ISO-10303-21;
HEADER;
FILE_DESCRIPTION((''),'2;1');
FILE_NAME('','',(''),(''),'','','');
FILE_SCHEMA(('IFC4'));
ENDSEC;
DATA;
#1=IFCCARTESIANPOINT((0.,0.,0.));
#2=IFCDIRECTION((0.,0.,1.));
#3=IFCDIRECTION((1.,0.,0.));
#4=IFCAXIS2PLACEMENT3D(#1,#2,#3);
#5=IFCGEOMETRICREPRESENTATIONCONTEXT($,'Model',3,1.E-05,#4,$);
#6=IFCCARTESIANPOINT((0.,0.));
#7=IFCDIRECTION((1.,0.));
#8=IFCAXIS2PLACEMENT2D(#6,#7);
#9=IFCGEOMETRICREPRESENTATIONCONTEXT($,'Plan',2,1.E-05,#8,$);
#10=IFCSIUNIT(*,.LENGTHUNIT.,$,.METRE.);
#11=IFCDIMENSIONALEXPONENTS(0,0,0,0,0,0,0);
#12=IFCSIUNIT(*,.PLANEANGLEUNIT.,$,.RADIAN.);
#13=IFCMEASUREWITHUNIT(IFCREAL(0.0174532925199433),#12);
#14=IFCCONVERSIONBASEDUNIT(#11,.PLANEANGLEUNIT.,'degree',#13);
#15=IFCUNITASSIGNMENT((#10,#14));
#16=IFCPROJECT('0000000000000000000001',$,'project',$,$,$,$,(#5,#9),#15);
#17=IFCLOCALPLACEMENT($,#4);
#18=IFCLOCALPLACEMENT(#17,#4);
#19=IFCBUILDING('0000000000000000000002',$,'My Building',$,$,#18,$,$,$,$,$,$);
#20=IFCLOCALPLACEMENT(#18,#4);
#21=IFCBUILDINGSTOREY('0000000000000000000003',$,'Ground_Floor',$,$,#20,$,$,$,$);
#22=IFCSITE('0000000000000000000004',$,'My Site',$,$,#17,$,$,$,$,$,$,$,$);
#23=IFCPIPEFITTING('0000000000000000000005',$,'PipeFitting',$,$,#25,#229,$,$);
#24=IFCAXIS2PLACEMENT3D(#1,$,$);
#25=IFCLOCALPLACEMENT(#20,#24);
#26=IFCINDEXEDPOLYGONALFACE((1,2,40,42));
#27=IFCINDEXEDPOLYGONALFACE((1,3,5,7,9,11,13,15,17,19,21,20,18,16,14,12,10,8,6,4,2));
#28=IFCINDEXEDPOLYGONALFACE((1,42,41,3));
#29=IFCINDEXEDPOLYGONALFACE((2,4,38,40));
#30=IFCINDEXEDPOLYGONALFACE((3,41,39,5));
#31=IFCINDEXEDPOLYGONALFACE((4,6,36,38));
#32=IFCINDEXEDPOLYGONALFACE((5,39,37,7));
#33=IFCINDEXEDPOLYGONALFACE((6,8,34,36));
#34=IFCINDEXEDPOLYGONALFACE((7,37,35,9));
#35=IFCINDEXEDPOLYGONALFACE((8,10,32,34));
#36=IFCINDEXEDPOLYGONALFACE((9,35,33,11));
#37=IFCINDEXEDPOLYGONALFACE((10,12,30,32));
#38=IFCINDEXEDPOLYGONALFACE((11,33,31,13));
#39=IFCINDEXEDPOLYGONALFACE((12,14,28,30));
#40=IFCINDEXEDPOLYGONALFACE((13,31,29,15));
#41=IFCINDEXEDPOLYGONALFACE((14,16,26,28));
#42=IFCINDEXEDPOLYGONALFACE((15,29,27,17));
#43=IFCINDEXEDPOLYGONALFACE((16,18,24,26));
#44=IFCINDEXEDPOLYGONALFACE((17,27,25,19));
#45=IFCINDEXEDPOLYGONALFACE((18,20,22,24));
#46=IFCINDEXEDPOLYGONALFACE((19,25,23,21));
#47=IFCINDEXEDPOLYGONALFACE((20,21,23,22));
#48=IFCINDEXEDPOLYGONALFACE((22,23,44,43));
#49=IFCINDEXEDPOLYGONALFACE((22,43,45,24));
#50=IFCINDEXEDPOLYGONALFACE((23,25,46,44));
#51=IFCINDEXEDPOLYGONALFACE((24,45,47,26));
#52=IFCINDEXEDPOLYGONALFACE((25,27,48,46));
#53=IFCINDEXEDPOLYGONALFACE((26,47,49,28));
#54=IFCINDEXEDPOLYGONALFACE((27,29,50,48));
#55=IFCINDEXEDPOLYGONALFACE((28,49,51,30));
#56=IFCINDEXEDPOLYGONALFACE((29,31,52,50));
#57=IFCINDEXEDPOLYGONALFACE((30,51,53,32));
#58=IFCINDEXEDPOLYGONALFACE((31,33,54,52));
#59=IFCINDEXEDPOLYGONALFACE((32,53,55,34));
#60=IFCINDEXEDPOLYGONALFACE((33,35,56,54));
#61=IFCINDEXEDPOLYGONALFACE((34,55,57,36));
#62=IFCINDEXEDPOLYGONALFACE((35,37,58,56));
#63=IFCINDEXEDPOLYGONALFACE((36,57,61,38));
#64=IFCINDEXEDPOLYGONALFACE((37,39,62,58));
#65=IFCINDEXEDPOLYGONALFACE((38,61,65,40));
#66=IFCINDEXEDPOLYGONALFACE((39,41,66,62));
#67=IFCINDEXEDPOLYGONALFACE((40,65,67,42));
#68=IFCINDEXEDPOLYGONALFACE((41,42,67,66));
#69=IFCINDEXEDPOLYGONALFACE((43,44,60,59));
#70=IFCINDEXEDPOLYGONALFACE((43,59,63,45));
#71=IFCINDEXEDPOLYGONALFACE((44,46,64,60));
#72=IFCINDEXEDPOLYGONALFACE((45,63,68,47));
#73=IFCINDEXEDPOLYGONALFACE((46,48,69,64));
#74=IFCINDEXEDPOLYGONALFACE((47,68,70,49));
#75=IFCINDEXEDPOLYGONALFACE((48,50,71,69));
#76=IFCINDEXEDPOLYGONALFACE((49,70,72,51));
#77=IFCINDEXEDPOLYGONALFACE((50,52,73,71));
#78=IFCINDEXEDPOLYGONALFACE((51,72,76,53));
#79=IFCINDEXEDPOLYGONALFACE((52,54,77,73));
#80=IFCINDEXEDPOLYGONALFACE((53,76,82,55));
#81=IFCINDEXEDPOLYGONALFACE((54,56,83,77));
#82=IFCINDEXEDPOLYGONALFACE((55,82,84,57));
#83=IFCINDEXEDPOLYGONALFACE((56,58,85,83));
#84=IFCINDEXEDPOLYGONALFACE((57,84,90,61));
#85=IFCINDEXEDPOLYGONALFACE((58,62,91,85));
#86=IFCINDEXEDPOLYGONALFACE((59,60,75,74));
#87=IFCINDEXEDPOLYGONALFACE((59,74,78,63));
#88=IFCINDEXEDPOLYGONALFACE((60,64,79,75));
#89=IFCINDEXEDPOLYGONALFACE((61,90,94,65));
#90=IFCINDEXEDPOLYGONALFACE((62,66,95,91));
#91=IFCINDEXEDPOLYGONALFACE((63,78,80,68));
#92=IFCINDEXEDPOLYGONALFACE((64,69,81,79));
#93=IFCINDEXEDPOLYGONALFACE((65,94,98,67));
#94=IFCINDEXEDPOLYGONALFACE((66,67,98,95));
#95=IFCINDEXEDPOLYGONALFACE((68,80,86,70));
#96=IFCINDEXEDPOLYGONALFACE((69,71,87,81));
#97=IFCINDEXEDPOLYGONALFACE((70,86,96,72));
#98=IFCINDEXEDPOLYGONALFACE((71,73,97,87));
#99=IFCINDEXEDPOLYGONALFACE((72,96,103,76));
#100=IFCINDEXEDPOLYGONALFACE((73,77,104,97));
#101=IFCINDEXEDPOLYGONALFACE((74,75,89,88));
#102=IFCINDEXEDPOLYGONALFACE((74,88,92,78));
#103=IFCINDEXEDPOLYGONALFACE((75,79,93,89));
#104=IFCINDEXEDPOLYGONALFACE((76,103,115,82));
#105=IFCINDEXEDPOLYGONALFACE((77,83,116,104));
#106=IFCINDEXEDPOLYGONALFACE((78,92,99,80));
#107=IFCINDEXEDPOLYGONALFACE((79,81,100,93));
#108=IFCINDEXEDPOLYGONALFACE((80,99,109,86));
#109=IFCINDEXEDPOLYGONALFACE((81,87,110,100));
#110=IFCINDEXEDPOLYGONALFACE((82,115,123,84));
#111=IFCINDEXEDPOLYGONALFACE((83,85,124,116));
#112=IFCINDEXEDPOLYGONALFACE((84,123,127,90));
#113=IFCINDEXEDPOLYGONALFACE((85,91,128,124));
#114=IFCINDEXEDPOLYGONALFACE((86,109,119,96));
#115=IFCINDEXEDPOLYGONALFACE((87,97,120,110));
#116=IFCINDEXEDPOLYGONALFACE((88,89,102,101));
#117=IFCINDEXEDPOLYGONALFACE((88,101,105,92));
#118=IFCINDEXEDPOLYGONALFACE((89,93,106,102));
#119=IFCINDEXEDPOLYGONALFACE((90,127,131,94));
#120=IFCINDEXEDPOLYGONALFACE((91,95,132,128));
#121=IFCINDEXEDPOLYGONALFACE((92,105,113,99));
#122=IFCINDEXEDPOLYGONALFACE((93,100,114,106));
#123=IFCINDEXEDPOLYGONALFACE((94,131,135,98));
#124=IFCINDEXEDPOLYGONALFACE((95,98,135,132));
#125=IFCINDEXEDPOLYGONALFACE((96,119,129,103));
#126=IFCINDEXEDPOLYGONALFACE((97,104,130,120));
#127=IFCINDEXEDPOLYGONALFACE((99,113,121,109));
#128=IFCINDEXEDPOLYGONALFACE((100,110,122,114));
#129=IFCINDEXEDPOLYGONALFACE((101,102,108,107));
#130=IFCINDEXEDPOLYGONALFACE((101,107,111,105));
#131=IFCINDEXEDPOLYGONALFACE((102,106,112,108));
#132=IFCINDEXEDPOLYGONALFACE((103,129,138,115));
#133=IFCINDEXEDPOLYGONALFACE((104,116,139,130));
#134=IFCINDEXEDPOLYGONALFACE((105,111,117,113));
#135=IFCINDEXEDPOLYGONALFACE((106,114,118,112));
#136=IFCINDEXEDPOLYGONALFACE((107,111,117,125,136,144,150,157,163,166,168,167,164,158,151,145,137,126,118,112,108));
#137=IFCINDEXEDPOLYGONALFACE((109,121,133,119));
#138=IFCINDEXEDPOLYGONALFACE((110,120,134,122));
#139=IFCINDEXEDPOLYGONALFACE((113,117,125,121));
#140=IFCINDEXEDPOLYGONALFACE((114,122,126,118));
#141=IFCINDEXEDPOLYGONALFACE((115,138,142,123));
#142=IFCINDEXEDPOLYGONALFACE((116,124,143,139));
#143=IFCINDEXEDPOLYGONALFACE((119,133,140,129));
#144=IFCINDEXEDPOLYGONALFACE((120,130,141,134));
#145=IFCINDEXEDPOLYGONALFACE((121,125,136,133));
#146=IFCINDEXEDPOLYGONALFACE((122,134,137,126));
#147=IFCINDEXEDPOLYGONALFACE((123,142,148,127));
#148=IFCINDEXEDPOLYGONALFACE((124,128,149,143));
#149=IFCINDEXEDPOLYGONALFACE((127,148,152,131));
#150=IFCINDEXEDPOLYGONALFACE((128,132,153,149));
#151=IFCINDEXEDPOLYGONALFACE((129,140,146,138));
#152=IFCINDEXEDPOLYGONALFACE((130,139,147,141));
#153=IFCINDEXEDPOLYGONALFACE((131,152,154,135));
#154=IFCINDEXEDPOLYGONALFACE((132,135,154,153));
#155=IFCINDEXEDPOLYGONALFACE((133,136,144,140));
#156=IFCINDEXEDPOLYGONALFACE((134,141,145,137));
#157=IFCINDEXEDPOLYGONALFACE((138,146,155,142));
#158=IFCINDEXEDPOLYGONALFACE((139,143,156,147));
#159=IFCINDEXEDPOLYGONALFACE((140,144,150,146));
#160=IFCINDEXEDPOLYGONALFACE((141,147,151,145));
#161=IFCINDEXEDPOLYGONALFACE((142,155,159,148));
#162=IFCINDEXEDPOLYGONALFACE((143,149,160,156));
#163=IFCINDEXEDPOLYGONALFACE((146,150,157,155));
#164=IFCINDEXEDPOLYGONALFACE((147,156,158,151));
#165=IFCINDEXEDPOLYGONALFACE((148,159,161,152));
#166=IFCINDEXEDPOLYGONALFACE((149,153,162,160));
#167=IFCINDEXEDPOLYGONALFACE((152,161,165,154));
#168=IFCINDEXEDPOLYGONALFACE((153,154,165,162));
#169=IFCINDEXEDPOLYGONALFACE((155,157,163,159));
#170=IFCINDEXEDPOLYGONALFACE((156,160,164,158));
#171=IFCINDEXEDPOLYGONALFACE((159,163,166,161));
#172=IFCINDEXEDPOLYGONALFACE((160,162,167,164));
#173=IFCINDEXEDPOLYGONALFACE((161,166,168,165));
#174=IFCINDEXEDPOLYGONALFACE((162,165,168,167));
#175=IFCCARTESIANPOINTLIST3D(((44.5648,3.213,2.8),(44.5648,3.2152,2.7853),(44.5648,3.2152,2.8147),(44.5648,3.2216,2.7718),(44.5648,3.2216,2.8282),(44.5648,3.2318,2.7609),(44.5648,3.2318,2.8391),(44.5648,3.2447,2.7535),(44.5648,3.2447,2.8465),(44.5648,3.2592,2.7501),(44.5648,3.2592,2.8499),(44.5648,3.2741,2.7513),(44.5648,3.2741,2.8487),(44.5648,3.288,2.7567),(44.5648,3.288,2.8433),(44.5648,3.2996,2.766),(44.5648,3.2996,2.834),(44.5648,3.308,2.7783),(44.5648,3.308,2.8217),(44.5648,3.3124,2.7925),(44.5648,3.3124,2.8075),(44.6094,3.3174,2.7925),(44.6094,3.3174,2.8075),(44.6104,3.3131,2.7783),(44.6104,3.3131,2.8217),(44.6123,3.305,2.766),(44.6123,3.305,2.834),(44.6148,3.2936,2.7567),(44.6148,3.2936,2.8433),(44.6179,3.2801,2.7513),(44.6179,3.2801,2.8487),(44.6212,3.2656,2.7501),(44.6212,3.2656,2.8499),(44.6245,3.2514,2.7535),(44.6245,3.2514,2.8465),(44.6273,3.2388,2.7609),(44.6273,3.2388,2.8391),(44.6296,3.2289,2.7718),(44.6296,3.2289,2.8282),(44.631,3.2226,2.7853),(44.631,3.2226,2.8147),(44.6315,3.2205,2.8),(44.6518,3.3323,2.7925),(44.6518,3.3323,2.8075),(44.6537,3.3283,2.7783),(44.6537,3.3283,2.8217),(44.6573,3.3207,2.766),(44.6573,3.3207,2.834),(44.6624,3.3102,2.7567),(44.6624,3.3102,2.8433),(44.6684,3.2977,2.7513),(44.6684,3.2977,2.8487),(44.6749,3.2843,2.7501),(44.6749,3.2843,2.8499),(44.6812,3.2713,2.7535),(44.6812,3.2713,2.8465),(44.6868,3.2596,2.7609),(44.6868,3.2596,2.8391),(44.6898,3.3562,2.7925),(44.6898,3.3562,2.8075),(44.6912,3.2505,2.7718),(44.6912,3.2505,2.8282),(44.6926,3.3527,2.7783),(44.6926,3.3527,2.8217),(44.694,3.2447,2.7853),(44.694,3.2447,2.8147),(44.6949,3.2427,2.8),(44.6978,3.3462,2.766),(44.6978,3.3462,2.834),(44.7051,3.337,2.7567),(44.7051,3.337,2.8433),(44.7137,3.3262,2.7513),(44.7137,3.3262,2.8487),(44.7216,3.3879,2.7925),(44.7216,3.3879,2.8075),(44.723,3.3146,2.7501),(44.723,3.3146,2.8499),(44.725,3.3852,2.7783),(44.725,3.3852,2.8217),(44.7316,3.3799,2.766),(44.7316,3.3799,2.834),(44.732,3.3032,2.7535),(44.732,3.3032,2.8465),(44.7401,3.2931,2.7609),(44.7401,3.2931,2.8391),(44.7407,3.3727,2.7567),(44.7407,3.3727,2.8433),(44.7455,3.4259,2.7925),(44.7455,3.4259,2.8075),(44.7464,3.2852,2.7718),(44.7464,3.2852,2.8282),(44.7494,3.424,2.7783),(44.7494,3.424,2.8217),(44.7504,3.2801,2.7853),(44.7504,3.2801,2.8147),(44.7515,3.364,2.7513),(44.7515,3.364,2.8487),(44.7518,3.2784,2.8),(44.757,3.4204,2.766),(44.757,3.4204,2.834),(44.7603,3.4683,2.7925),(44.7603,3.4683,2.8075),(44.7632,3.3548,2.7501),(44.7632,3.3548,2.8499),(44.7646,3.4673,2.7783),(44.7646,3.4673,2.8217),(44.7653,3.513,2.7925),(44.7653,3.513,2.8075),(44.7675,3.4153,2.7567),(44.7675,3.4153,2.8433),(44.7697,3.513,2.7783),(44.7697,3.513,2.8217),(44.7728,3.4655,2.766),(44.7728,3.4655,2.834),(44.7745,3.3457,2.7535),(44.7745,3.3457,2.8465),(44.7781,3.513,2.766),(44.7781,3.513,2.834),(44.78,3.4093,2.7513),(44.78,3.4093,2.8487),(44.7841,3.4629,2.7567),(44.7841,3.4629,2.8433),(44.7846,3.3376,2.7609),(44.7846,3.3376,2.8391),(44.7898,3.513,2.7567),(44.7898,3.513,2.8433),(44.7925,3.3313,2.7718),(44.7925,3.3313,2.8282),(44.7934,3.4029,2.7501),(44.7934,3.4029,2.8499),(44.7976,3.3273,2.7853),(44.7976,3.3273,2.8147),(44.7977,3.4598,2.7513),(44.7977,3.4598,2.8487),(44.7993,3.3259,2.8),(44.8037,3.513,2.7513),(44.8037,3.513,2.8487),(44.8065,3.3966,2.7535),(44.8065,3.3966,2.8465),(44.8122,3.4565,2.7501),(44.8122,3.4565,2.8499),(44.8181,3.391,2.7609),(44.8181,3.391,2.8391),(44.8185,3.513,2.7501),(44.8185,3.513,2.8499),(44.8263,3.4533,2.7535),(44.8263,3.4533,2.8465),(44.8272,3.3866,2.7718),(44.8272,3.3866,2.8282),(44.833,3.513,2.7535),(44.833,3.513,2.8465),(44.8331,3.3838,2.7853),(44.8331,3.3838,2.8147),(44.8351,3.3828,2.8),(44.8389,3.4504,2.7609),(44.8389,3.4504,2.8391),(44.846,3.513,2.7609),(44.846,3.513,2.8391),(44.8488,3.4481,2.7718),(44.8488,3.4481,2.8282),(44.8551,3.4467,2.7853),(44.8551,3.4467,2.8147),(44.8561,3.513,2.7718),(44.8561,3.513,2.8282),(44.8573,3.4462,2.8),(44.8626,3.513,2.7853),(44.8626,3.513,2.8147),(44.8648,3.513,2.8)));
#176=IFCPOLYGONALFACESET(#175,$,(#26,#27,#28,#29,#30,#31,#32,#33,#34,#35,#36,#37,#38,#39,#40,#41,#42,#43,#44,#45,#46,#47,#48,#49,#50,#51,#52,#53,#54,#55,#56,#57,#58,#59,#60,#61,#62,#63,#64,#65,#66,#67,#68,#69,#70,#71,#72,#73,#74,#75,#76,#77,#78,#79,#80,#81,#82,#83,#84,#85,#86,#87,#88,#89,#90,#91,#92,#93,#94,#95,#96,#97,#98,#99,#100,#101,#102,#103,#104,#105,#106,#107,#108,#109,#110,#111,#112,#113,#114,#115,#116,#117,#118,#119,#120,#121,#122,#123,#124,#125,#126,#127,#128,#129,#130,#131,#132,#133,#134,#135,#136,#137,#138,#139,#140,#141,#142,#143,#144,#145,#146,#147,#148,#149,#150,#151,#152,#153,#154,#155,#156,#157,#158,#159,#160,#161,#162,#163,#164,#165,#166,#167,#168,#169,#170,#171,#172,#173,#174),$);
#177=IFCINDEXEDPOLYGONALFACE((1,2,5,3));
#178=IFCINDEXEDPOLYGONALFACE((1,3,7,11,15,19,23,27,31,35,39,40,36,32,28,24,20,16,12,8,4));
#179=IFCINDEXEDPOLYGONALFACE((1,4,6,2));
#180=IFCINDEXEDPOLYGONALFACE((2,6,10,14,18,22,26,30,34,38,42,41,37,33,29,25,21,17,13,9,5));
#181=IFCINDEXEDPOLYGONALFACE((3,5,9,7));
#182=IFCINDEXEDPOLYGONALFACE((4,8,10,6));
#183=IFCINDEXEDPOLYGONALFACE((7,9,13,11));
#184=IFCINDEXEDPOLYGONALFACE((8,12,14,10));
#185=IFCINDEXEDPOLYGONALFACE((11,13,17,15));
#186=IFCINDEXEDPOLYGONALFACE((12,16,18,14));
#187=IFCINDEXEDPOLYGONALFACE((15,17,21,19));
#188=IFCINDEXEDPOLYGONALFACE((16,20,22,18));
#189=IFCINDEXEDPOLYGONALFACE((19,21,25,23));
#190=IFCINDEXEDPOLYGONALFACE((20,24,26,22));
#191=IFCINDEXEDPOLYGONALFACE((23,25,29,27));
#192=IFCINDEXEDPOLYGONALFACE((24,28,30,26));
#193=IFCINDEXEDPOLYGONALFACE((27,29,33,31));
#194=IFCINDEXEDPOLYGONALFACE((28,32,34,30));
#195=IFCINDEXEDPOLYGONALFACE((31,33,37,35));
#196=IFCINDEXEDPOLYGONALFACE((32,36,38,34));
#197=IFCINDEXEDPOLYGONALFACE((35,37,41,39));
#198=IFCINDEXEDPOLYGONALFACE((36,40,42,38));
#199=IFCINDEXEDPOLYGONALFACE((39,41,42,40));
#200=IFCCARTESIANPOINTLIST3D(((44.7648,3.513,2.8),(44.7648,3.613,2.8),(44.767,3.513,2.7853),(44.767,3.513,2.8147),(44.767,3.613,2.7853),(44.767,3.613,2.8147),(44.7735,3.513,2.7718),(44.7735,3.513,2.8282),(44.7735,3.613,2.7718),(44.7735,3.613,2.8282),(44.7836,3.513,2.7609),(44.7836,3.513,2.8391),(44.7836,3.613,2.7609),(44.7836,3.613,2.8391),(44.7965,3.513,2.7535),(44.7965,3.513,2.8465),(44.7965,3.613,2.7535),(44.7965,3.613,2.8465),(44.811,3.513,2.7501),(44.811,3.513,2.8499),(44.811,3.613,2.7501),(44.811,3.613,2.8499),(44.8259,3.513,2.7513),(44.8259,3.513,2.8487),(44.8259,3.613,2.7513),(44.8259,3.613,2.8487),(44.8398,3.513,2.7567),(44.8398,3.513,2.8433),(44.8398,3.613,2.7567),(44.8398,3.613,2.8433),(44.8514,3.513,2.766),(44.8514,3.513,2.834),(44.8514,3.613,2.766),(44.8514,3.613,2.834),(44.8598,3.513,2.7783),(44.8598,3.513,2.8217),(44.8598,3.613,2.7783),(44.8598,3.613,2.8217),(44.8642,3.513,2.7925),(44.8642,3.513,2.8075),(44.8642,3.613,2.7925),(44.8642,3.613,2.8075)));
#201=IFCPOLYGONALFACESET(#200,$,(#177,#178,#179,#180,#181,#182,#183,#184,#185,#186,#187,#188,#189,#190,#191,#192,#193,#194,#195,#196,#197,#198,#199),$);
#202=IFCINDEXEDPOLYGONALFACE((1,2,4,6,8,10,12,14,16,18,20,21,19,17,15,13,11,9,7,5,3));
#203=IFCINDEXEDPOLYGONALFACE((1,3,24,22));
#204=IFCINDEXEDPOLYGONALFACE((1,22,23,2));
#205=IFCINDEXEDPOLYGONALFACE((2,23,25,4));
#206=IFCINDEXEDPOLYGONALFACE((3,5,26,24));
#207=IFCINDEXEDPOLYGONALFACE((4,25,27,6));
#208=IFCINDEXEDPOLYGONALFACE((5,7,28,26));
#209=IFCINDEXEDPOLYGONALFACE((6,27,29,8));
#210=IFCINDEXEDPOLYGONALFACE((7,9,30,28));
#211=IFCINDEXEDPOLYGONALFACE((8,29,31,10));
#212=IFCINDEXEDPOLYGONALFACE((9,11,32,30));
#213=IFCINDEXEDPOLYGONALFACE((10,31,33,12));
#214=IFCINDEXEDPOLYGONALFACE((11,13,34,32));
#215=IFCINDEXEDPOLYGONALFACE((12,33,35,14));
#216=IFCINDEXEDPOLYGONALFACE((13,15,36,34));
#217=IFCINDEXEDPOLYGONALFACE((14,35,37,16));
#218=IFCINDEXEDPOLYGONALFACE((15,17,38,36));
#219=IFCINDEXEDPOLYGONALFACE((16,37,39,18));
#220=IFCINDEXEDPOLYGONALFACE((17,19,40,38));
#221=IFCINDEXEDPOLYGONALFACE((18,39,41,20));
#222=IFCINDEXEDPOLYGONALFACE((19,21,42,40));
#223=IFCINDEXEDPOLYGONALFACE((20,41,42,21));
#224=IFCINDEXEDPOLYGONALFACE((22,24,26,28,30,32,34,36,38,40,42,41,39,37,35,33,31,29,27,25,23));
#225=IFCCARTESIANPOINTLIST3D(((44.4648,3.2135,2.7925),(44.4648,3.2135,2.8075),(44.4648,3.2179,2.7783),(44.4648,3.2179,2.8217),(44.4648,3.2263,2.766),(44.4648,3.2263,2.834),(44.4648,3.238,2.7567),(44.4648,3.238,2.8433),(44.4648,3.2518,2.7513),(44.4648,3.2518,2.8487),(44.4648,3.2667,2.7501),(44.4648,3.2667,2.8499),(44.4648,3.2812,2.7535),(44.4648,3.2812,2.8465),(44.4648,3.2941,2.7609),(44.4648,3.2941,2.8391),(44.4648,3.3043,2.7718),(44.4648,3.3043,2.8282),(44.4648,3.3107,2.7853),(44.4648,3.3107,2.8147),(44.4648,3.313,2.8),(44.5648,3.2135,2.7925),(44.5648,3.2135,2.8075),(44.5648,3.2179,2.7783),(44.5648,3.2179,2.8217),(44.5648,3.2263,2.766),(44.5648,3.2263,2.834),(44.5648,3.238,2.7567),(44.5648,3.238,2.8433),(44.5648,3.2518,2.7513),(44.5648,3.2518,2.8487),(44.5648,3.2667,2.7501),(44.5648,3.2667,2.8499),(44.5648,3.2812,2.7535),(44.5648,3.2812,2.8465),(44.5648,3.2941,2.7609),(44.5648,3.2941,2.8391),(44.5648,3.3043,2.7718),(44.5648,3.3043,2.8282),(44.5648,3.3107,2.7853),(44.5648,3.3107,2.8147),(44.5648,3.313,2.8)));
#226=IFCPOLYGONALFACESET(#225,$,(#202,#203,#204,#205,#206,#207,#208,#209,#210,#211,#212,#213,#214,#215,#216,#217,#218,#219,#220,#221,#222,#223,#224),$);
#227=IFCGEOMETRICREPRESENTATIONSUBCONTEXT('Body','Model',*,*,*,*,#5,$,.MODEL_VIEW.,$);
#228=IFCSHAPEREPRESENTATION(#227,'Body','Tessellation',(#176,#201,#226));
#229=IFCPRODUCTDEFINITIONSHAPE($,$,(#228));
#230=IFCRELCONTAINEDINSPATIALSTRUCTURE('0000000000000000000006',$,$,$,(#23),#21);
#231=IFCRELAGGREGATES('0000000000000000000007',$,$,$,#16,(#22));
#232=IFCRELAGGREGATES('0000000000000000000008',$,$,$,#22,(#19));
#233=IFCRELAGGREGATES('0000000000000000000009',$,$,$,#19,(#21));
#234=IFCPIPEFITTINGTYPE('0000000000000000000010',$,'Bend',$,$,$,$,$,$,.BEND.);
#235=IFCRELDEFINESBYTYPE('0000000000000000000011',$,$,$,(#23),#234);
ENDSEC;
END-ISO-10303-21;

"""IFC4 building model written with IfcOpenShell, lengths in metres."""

from ifc_helpers import new_model, entity, si_unit, converted_unit, frame, origin_with_axes, origin_2d_with_axis, place, context, subcontext, project, spatial, circle, extrude, source, transform, mapped, type_object, type_shapes, element, save


model = new_model("IFC4")

# Units and contexts
model_context = context("Model", 3, precision=1e-05, world=origin_with_axes())
plan_context = context("Plan", 2, precision=1e-05, world=origin_2d_with_axis())
body_context = subcontext(model_context, "Body", "Model", "MODEL_VIEW")
ifc_project = project(units=[si_unit("LENGTHUNIT", "METRE"), converted_unit("PLANEANGLEUNIT", "degree", entity("IfcReal", 0.0174532925199433), si_unit("PLANEANGLEUNIT", "RADIAN"), dimensions=[0, 0, 0, 0, 0, 0, 0])], contexts=[model_context, plan_context])

# Site, building, storey
site_placement = place(None, origin_with_axes())
site = spatial("IfcSite", under=ifc_project, at=site_placement, Name="My Site")
building_placement = place(site_placement, origin_with_axes())
building = spatial("IfcBuilding", under=site, at=building_placement, Name="My Building")
storey_placement = place(building_placement, origin_with_axes())
storey = spatial("IfcBuildingStorey", under=building, at=storey_placement, Name="Ground_Floor")

# Pipe fitting
pipe_fitting_type = type_object("IfcPipeFittingType", Name="Bend", PredefinedType="BEND")
shared_shape_1 = source(origin_with_axes(), body_context, "Body", "SolidModel", [
    entity("IfcSweptDiskSolid", entity("IfcIndexedPolyCurve", entity("IfcCartesianPointList3D", [[0.0, 0.0, -0.1], [0.0732, 0.0, -0.2768], [0.25, 0.0, -0.35]]), [entity("IfcArcIndex", [1, 2, 3])]), 0.05),
    extrude(circle(Radius=0.05), origin_with_axes(), (0.0, 0.0, -1.0), 0.1),
    extrude(circle(Radius=0.05), frame((0.25, 0.0, -0.35), z_axis=(1.0, 0.0, 0.0), x_axis=(0.0, 0.0, 1.0)), (0.0, 0.0, 1.0), 0.1),
])
type_shapes(pipe_fitting_type, [shared_shape_1])
for number, where, z_axis, x_axis, name in (
    (1, (44.8148, 3.613, 2.8), (0.0, 1.0, 0.0), (-1.0, 0.0, 0.0), "PipeFitting"),
):
    element("IfcPipeFitting", number, at=place(storey_placement, frame(where, z_axis=z_axis, x_axis=x_axis)), inside=storey, type_object=pipe_fitting_type, Name=name, context=body_context, shape_type="MappedRepresentation", body=[
        mapped(shared_shape_1, transform((0.0, 0.0, 0.0), x_axis=(1.0, 0.0, 0.0), y_axis=(0.0, 1.0, 0.0), z_axis=(0.0, 0.0, 1.0), scale=1.0)),
    ])

save(model, "model.ifc")
